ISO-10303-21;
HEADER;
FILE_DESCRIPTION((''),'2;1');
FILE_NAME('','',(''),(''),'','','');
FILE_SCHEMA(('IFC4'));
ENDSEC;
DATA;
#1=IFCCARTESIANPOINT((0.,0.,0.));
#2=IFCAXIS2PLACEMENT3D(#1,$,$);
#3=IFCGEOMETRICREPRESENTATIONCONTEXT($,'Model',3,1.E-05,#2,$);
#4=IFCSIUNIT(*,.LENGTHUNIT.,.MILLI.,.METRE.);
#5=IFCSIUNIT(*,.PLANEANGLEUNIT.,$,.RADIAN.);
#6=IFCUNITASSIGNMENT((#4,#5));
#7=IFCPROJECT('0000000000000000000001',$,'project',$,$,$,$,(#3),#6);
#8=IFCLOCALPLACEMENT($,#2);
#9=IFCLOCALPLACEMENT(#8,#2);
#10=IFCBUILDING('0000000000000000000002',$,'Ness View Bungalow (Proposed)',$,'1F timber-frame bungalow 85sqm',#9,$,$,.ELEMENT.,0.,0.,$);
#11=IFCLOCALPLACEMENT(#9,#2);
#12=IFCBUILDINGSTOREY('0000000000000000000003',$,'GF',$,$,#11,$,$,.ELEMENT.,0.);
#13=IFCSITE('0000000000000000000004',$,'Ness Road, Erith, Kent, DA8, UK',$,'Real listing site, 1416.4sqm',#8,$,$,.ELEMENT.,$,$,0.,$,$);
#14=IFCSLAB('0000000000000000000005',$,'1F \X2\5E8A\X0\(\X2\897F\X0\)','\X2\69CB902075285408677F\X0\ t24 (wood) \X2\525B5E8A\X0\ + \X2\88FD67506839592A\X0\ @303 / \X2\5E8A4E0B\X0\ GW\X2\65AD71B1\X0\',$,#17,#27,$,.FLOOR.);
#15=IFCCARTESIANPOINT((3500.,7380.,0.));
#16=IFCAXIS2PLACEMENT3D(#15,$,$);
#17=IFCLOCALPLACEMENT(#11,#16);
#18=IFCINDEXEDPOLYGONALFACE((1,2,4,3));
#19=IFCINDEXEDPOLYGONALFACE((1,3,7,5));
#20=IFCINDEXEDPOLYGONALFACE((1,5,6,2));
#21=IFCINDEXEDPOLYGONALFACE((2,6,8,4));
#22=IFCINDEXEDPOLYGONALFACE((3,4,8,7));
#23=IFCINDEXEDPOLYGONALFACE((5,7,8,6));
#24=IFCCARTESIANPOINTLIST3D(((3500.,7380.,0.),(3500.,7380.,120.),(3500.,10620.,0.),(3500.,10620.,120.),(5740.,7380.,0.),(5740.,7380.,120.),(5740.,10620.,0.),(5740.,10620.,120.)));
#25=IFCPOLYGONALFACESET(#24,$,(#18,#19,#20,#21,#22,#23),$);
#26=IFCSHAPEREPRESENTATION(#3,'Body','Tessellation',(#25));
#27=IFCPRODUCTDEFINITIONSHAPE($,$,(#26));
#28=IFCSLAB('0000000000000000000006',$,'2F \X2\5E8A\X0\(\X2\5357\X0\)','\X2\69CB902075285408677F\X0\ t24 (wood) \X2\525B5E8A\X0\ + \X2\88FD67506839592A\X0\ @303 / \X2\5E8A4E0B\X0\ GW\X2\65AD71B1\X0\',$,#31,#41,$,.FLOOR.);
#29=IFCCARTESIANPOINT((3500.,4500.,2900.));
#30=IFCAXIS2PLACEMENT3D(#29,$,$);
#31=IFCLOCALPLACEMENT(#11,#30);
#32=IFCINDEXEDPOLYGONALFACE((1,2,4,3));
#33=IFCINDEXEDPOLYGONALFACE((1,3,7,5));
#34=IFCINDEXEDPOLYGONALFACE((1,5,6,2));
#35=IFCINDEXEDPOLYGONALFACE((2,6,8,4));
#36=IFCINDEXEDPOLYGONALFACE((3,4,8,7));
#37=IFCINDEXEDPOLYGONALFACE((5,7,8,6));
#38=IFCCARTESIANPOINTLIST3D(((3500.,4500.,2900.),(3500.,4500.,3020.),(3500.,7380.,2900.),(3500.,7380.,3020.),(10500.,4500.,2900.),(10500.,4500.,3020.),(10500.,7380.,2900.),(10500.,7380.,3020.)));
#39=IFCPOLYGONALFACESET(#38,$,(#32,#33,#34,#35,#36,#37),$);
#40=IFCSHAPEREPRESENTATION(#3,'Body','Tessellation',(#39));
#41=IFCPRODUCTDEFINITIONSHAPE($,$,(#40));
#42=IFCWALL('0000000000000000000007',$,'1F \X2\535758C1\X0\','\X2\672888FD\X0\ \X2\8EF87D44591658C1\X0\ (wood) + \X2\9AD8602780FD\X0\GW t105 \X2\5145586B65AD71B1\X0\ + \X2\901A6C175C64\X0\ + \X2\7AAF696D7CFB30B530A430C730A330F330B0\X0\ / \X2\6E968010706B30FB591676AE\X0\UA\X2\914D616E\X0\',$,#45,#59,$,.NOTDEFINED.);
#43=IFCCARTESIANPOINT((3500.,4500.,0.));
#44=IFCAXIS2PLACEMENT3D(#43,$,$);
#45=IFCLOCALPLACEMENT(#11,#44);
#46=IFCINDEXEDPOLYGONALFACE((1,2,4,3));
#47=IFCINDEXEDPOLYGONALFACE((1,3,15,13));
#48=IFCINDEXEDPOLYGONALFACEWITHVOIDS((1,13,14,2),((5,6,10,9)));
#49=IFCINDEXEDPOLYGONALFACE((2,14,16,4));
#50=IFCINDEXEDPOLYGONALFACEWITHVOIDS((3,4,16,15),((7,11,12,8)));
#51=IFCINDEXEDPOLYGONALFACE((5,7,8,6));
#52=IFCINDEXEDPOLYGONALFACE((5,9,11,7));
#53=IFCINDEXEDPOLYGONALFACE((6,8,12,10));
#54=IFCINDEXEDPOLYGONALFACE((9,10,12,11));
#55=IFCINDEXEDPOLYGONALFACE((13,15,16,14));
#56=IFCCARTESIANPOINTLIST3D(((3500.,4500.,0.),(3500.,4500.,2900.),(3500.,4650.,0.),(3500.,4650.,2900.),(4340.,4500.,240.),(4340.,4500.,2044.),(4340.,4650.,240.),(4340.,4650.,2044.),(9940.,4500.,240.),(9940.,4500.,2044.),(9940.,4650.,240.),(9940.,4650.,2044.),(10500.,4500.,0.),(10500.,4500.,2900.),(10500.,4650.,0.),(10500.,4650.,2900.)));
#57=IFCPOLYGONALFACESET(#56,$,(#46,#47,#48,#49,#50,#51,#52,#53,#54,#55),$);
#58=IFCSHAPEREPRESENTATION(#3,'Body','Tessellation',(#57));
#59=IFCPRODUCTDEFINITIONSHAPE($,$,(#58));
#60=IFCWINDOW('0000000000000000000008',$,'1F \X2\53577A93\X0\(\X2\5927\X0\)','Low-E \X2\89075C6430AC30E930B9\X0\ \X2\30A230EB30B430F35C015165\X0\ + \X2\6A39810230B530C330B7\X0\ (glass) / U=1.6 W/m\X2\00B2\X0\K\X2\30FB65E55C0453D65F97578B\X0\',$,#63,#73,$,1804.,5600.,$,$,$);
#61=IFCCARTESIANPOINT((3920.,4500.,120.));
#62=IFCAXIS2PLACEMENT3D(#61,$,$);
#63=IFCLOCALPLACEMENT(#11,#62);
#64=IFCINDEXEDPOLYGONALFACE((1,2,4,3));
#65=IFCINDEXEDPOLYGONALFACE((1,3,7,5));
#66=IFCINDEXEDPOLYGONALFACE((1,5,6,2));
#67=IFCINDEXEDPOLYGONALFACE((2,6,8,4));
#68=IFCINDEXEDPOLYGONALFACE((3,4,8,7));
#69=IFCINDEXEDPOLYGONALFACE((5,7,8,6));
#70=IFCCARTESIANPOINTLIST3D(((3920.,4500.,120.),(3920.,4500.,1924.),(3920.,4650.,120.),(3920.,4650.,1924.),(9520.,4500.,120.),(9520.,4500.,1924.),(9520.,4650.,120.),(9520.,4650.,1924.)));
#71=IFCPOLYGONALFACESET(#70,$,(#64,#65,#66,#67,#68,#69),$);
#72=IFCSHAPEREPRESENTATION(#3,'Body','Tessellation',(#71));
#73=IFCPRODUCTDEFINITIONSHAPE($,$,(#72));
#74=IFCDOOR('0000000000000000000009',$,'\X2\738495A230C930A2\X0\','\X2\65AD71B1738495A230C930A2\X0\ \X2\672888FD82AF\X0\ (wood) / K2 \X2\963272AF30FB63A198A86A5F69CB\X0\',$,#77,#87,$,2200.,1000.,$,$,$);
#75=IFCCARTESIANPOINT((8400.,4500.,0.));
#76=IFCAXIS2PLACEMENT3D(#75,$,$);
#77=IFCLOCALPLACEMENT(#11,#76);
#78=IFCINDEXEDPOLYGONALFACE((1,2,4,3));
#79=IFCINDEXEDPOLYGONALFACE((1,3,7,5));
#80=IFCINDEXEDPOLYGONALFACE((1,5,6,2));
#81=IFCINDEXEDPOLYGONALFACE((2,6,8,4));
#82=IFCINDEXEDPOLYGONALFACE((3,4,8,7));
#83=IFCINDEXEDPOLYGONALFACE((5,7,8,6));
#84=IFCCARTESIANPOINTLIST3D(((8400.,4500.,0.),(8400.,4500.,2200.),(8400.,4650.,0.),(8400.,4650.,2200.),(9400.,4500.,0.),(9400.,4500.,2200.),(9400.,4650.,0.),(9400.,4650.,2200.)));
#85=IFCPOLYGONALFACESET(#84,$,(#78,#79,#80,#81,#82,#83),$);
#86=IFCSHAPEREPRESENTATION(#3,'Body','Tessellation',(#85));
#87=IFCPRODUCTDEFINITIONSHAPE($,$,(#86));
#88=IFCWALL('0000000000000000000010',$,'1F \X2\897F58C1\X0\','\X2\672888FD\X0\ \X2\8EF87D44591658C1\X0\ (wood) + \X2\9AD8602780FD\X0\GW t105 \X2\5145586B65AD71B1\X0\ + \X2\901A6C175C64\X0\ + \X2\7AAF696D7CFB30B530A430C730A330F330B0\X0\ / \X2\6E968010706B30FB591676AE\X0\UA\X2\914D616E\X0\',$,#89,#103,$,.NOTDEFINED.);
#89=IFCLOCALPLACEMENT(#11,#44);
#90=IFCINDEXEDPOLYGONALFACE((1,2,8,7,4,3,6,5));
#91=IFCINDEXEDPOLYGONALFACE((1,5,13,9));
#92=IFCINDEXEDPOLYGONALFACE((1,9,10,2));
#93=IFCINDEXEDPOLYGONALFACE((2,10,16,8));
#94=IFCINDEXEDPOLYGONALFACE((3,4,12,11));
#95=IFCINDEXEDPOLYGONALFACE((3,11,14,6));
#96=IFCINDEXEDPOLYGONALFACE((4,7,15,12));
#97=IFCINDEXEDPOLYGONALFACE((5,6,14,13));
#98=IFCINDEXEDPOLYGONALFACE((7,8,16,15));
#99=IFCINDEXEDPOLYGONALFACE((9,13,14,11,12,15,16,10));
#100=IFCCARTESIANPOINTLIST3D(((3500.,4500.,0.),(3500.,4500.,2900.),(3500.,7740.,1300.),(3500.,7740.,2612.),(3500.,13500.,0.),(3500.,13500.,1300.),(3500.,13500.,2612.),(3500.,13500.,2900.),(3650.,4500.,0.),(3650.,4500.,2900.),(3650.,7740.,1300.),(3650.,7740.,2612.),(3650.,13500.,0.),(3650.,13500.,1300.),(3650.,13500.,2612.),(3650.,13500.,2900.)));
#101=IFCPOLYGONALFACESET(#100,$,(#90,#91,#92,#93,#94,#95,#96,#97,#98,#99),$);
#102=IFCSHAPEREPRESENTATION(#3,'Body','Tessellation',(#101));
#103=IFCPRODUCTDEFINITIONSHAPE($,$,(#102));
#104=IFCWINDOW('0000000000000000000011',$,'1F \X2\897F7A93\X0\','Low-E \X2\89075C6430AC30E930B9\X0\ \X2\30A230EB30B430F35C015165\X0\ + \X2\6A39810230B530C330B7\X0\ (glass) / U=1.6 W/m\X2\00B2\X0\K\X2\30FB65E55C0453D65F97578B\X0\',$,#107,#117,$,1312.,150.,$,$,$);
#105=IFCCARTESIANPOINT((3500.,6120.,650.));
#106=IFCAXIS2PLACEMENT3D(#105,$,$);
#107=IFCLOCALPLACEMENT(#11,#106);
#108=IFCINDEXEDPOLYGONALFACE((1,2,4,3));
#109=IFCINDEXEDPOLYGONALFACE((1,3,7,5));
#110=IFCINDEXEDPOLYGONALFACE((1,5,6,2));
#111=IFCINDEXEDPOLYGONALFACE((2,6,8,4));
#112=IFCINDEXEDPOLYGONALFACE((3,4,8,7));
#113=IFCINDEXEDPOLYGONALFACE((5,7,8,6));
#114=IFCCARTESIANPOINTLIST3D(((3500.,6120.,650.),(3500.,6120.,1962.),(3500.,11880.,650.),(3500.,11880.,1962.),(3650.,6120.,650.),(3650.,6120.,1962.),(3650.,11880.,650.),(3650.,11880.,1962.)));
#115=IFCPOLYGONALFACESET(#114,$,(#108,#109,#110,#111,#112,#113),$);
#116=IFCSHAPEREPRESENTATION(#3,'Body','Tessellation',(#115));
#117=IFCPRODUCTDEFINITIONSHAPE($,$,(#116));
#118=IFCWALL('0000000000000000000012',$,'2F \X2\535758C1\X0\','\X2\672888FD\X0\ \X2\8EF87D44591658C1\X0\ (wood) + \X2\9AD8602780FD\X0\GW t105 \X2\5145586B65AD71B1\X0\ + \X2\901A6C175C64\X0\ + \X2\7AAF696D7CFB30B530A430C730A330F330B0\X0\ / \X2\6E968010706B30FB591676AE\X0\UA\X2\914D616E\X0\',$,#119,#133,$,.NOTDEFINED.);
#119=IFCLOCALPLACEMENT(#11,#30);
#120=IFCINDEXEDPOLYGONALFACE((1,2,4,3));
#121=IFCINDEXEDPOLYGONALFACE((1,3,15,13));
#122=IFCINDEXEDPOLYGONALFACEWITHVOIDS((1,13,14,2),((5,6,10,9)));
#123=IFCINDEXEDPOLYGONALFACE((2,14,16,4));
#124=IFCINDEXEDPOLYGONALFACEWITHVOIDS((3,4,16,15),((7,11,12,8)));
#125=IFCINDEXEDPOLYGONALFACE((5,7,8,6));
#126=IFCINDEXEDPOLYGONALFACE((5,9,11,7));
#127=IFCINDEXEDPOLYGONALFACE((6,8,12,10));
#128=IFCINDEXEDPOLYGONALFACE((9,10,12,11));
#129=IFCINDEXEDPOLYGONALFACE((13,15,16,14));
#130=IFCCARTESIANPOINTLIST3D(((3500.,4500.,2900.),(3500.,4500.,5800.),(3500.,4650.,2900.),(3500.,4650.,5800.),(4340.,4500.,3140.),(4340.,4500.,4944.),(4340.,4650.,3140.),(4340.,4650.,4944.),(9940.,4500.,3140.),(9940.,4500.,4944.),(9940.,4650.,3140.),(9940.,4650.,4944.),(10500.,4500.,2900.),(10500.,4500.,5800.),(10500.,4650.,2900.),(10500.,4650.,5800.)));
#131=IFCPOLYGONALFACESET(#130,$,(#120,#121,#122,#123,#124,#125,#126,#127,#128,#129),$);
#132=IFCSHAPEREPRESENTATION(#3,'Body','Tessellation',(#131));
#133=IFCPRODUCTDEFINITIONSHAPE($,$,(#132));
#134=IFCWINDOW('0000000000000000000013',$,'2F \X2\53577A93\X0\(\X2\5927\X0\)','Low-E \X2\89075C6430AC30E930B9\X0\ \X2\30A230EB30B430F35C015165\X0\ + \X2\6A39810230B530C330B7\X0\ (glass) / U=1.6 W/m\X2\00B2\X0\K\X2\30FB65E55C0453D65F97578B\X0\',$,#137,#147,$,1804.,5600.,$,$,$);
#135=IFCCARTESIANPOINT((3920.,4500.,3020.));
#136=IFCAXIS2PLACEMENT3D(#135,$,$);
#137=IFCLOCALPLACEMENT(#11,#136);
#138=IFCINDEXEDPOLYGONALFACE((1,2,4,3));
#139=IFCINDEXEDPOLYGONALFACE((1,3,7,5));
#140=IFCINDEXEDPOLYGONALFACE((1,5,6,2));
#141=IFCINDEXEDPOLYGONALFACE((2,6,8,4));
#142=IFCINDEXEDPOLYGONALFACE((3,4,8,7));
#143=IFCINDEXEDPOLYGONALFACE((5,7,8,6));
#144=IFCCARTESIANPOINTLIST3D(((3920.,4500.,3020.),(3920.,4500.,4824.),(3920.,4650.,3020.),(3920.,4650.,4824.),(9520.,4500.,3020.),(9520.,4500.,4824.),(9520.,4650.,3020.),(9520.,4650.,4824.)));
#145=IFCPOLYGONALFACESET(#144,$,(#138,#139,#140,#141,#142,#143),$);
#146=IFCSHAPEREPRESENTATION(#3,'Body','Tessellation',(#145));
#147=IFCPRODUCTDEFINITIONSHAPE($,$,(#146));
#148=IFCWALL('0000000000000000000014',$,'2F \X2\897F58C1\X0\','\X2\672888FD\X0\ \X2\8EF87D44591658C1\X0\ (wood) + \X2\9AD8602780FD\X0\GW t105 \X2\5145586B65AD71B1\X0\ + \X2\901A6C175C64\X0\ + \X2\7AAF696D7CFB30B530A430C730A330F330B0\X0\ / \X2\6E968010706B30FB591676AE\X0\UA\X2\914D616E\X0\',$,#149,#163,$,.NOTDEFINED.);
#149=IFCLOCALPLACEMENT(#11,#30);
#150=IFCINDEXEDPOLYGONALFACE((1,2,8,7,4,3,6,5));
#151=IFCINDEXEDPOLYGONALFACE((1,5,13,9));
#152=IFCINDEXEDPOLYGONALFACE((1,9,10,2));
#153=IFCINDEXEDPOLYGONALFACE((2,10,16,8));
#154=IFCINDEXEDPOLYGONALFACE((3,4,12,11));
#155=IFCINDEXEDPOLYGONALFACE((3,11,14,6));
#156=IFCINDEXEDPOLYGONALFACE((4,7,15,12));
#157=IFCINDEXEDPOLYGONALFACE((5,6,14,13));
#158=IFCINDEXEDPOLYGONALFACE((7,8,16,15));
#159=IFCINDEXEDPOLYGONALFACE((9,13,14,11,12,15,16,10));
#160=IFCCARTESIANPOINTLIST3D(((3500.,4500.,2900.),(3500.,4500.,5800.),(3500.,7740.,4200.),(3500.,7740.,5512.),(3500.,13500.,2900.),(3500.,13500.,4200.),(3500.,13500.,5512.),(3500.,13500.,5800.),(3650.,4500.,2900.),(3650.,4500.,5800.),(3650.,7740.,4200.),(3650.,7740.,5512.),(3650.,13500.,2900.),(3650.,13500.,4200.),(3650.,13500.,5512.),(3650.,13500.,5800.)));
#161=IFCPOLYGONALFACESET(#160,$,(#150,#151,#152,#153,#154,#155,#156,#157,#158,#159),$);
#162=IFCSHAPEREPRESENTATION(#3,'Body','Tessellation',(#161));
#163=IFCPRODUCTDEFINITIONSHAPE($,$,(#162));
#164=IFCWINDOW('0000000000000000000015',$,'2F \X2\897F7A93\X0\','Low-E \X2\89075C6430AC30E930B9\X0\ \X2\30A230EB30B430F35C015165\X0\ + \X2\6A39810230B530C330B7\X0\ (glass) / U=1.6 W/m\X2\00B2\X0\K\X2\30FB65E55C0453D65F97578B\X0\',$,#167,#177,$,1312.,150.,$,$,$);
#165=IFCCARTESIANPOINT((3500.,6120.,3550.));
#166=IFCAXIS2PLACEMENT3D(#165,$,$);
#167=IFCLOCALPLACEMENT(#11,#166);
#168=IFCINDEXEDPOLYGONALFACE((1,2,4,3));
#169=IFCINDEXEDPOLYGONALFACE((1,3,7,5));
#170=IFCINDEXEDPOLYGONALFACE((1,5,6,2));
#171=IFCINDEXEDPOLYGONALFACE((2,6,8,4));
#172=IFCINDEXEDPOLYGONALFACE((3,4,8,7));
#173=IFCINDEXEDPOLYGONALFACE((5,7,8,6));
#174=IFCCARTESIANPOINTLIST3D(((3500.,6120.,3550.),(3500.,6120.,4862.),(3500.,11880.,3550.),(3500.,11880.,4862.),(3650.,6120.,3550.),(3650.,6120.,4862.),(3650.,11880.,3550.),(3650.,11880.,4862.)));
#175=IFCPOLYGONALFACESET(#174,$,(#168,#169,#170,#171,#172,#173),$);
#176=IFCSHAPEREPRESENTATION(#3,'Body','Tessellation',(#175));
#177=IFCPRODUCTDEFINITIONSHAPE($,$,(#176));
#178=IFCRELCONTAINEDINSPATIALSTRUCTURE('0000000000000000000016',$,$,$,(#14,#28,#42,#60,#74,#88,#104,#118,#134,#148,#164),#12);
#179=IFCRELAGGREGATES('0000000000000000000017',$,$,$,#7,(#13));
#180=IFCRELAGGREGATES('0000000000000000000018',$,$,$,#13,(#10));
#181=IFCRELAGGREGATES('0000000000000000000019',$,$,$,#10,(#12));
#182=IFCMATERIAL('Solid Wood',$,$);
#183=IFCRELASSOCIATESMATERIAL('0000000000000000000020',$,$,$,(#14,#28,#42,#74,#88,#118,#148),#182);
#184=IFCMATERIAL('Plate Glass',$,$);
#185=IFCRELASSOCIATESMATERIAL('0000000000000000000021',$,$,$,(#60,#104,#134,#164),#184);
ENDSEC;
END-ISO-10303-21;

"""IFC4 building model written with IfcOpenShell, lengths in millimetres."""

from ifc_helpers import new_model, si_unit, frame, frame_2d, origin, place, context, project, spatial, rectangle, extrude, material, element, fill, save


model = new_model("IFC4")

# Units and contexts
model_context = context("Model", 3, precision=1e-05, world=origin())
ifc_project = project(units=[si_unit("LENGTHUNIT", "METRE", prefix="MILLI"), si_unit("PLANEANGLEUNIT", "RADIAN")], contexts=[model_context])

# Site, building, storey
site_placement = place(None, origin())
site = spatial("IfcSite", under=ifc_project, at=site_placement, Name="Ness Road, Erith, Kent, DA8, UK", ObjectType="Real listing site, 1416.4sqm", CompositionType="ELEMENT", RefElevation=0.0)
building_placement = place(site_placement, origin())
building = spatial("IfcBuilding", under=site, at=building_placement, Name="Ness View Bungalow (Proposed)", ObjectType="1F timber-frame bungalow 85sqm", CompositionType="ELEMENT", ElevationOfRefHeight=0.0, ElevationOfTerrain=0.0)
storey_placement = place(building_placement, origin())
storey = spatial("IfcBuildingStorey", under=building, at=storey_placement, Name="GF", CompositionType="ELEMENT", Elevation=0.0)

# Slabs
ifc_material_1 = material(Name="Solid Wood")
slab_1_placement = place(storey_placement, frame((3500.0, 7380.0, 0.0)))
element("IfcSlab", 1, at=slab_1_placement, inside=storey, material=ifc_material_1, Name="1F 床(西)", Description="構造用合板 t24 (wood) 剛床 + 製材根太 @303 / 床下 GW断熱", PredefinedType="FLOOR", context=model_context, shape_type="SweptSolid", body=[
    extrude(rectangle(XDim=2240.0, YDim=3240.0, at=frame_2d((1120.0, 1620.0))), frame((3500.0, 7380.0, 0.0)), (0.0, 0.0, 1.0), 120.0),
])
slab_2_placement = place(storey_placement, frame((3500.0, 4500.0, 2900.0)))
element("IfcSlab", 2, at=slab_2_placement, inside=storey, material=ifc_material_1, Name="2F 床(南)", Description="構造用合板 t24 (wood) 剛床 + 製材根太 @303 / 床下 GW断熱", PredefinedType="FLOOR", context=model_context, shape_type="SweptSolid", body=[
    extrude(rectangle(XDim=7000.0, YDim=2880.0, at=frame_2d((3500.0, 1440.0))), frame((3500.0, 4500.0, 2900.0)), (0.0, 0.0, 1.0), 120.0),
])

# Wall, openings, window, door
wall_1_placement = place(storey_placement, frame((3500.0, 4500.0, 0.0)))
wall_1 = element("IfcWall", 3, at=wall_1_placement, inside=storey, material=ifc_material_1, Name="1F 南壁", Description="木製 軸組外壁 (wood) + 高性能GW t105 充填断熱 + 通気層 + 窯業系サイディング / 準耐火・外皮UA配慮", PredefinedType="NOTDEFINED", context=model_context, shape_type="SweptSolid", body=[
    extrude(rectangle(XDim=7000.0, YDim=150.0, at=frame_2d((3500.0, 75.0))), frame((3500.0, 4500.0, 0.0)), (0.0, 0.0, 1.0), 2900.0),
])
opening_1_placement = place(storey_placement, frame((3920.0, 4500.0, 120.0)))
opening_1 = element("IfcOpeningElement", 4, at=opening_1_placement, cuts=wall_1, PredefinedType="NOTDEFINED", context=model_context, shape_type="SweptSolid", body=[
    extrude(rectangle(XDim=5600.0, YDim=150.0, at=frame_2d((2800.0, 75.0))), frame((3920.0, 4500.0, 120.0)), (0.0, 0.0, 1.0), 1804.0),
])
opening_2_placement = place(storey_placement, frame((8400.0, 4500.0, 0.0)))
opening_2 = element("IfcOpeningElement", 5, at=opening_2_placement, cuts=wall_1, PredefinedType="NOTDEFINED", context=model_context, shape_type="SweptSolid", body=[
    extrude(rectangle(XDim=1000.0, YDim=150.0, at=frame_2d((500.0, 75.0))), frame((8400.0, 4500.0, 0.0)), (0.0, 0.0, 1.0), 2200.0),
])
ifc_material_2 = material(Name="Plate Glass")
window_1_placement = place(storey_placement, frame((3920.0, 4500.0, 120.0)))
window_1 = element("IfcWindow", 6, at=window_1_placement, inside=storey, material=ifc_material_2, Name="1F 南窓(大)", Description="Low-E 複層ガラス アルゴン封入 + 樹脂サッシ (glass) / U=1.6 W/m²K・日射取得型", OverallHeight=1804.0, OverallWidth=5600.0, context=model_context, shape_type="SweptSolid", body=[
    extrude(rectangle(XDim=5600.0, YDim=150.0, at=frame_2d((2800.0, 75.0))), frame((3920.0, 4500.0, 120.0)), (0.0, 0.0, 1.0), 1804.0),
])
fill(opening_1, window_1)
door_placement = place(storey_placement, frame((8400.0, 4500.0, 0.0)))
door = element("IfcDoor", 7, at=door_placement, inside=storey, material=ifc_material_1, Name="玄関ドア", Description="断熱玄関ドア 木製芯 (wood) / K2 防犯・採風機構", OverallHeight=2200.0, OverallWidth=1000.0, context=model_context, shape_type="SweptSolid", body=[
    extrude(rectangle(XDim=1000.0, YDim=150.0, at=frame_2d((500.0, 75.0))), frame((8400.0, 4500.0, 0.0)), (0.0, 0.0, 1.0), 2200.0),
])
fill(opening_2, door)

# Walls, openings, windows
wall_2_placement = place(storey_placement, frame((3500.0, 4500.0, 0.0)))
wall_2 = element("IfcWall", 8, at=wall_2_placement, inside=storey, material=ifc_material_1, Name="1F 西壁", Description="木製 軸組外壁 (wood) + 高性能GW t105 充填断熱 + 通気層 + 窯業系サイディング / 準耐火・外皮UA配慮", PredefinedType="NOTDEFINED", context=model_context, shape_type="SweptSolid", body=[
    extrude(rectangle(XDim=150.0, YDim=9000.0, at=frame_2d((75.0, 4500.0))), frame((3500.0, 4500.0, 0.0)), (0.0, 0.0, 1.0), 2900.0),
])
opening_3_placement = place(storey_placement, frame((3500.0, 6120.0, 650.0)))
opening_3 = element("IfcOpeningElement", 9, at=opening_3_placement, cuts=wall_2, PredefinedType="NOTDEFINED", context=model_context, shape_type="SweptSolid", body=[
    extrude(rectangle(XDim=150.0, YDim=5760.0, at=frame_2d((75.0, 2880.0))), frame((3500.0, 6120.0, 650.0)), (0.0, 0.0, 1.0), 1312.0),
])
window_2_placement = place(storey_placement, frame((3500.0, 6120.0, 650.0)))
window_2 = element("IfcWindow", 10, at=window_2_placement, inside=storey, material=ifc_material_2, Name="1F 西窓", Description="Low-E 複層ガラス アルゴン封入 + 樹脂サッシ (glass) / U=1.6 W/m²K・日射取得型", OverallHeight=1312.0, OverallWidth=150.0, context=model_context, shape_type="SweptSolid", body=[
    extrude(rectangle(XDim=150.0, YDim=5760.0, at=frame_2d((75.0, 2880.0))), frame((3500.0, 6120.0, 650.0)), (0.0, 0.0, 1.0), 1312.0),
])
fill(opening_3, window_2)
wall_3_placement = place(storey_placement, frame((3500.0, 4500.0, 2900.0)))
wall_3 = element("IfcWall", 11, at=wall_3_placement, inside=storey, material=ifc_material_1, Name="2F 南壁", Description="木製 軸組外壁 (wood) + 高性能GW t105 充填断熱 + 通気層 + 窯業系サイディング / 準耐火・外皮UA配慮", PredefinedType="NOTDEFINED", context=model_context, shape_type="SweptSolid", body=[
    extrude(rectangle(XDim=7000.0, YDim=150.0, at=frame_2d((3500.0, 75.0))), frame((3500.0, 4500.0, 2900.0)), (0.0, 0.0, 1.0), 2900.0),
])
opening_4_placement = place(storey_placement, frame((3920.0, 4500.0, 3020.0)))
opening_4 = element("IfcOpeningElement", 12, at=opening_4_placement, cuts=wall_3, PredefinedType="NOTDEFINED", context=model_context, shape_type="SweptSolid", body=[
    extrude(rectangle(XDim=5600.0, YDim=150.0, at=frame_2d((2800.0, 75.0))), frame((3920.0, 4500.0, 3020.0)), (0.0, 0.0, 1.0), 1804.0),
])
window_3_placement = place(storey_placement, frame((3920.0, 4500.0, 3020.0)))
window_3 = element("IfcWindow", 13, at=window_3_placement, inside=storey, material=ifc_material_2, Name="2F 南窓(大)", Description="Low-E 複層ガラス アルゴン封入 + 樹脂サッシ (glass) / U=1.6 W/m²K・日射取得型", OverallHeight=1804.0, OverallWidth=5600.0, context=model_context, shape_type="SweptSolid", body=[
    extrude(rectangle(XDim=5600.0, YDim=150.0, at=frame_2d((2800.0, 75.0))), frame((3920.0, 4500.0, 3020.0)), (0.0, 0.0, 1.0), 1804.0),
])
fill(opening_4, window_3)
wall_4_placement = place(storey_placement, frame((3500.0, 4500.0, 2900.0)))
wall_4 = element("IfcWall", 14, at=wall_4_placement, inside=storey, material=ifc_material_1, Name="2F 西壁", Description="木製 軸組外壁 (wood) + 高性能GW t105 充填断熱 + 通気層 + 窯業系サイディング / 準耐火・外皮UA配慮", PredefinedType="NOTDEFINED", context=model_context, shape_type="SweptSolid", body=[
    extrude(rectangle(XDim=150.0, YDim=9000.0, at=frame_2d((75.0, 4500.0))), frame((3500.0, 4500.0, 2900.0)), (0.0, 0.0, 1.0), 2900.0),
])
opening_5_placement = place(storey_placement, frame((3500.0, 6120.0, 3550.0)))
opening_5 = element("IfcOpeningElement", 15, at=opening_5_placement, cuts=wall_4, PredefinedType="NOTDEFINED", context=model_context, shape_type="SweptSolid", body=[
    extrude(rectangle(XDim=150.0, YDim=5760.0, at=frame_2d((75.0, 2880.0))), frame((3500.0, 6120.0, 3550.0)), (0.0, 0.0, 1.0), 1312.0),
])
window_4_placement = place(storey_placement, frame((3500.0, 6120.0, 3550.0)))
window_4 = element("IfcWindow", 16, at=window_4_placement, inside=storey, material=ifc_material_2, Name="2F 西窓", Description="Low-E 複層ガラス アルゴン封入 + 樹脂サッシ (glass) / U=1.6 W/m²K・日射取得型", OverallHeight=1312.0, OverallWidth=150.0, context=model_context, shape_type="SweptSolid", body=[
    extrude(rectangle(XDim=150.0, YDim=5760.0, at=frame_2d((75.0, 2880.0))), frame((3500.0, 6120.0, 3550.0)), (0.0, 0.0, 1.0), 1312.0),
])
fill(opening_5, window_4)

save(model, "model.ifc")
